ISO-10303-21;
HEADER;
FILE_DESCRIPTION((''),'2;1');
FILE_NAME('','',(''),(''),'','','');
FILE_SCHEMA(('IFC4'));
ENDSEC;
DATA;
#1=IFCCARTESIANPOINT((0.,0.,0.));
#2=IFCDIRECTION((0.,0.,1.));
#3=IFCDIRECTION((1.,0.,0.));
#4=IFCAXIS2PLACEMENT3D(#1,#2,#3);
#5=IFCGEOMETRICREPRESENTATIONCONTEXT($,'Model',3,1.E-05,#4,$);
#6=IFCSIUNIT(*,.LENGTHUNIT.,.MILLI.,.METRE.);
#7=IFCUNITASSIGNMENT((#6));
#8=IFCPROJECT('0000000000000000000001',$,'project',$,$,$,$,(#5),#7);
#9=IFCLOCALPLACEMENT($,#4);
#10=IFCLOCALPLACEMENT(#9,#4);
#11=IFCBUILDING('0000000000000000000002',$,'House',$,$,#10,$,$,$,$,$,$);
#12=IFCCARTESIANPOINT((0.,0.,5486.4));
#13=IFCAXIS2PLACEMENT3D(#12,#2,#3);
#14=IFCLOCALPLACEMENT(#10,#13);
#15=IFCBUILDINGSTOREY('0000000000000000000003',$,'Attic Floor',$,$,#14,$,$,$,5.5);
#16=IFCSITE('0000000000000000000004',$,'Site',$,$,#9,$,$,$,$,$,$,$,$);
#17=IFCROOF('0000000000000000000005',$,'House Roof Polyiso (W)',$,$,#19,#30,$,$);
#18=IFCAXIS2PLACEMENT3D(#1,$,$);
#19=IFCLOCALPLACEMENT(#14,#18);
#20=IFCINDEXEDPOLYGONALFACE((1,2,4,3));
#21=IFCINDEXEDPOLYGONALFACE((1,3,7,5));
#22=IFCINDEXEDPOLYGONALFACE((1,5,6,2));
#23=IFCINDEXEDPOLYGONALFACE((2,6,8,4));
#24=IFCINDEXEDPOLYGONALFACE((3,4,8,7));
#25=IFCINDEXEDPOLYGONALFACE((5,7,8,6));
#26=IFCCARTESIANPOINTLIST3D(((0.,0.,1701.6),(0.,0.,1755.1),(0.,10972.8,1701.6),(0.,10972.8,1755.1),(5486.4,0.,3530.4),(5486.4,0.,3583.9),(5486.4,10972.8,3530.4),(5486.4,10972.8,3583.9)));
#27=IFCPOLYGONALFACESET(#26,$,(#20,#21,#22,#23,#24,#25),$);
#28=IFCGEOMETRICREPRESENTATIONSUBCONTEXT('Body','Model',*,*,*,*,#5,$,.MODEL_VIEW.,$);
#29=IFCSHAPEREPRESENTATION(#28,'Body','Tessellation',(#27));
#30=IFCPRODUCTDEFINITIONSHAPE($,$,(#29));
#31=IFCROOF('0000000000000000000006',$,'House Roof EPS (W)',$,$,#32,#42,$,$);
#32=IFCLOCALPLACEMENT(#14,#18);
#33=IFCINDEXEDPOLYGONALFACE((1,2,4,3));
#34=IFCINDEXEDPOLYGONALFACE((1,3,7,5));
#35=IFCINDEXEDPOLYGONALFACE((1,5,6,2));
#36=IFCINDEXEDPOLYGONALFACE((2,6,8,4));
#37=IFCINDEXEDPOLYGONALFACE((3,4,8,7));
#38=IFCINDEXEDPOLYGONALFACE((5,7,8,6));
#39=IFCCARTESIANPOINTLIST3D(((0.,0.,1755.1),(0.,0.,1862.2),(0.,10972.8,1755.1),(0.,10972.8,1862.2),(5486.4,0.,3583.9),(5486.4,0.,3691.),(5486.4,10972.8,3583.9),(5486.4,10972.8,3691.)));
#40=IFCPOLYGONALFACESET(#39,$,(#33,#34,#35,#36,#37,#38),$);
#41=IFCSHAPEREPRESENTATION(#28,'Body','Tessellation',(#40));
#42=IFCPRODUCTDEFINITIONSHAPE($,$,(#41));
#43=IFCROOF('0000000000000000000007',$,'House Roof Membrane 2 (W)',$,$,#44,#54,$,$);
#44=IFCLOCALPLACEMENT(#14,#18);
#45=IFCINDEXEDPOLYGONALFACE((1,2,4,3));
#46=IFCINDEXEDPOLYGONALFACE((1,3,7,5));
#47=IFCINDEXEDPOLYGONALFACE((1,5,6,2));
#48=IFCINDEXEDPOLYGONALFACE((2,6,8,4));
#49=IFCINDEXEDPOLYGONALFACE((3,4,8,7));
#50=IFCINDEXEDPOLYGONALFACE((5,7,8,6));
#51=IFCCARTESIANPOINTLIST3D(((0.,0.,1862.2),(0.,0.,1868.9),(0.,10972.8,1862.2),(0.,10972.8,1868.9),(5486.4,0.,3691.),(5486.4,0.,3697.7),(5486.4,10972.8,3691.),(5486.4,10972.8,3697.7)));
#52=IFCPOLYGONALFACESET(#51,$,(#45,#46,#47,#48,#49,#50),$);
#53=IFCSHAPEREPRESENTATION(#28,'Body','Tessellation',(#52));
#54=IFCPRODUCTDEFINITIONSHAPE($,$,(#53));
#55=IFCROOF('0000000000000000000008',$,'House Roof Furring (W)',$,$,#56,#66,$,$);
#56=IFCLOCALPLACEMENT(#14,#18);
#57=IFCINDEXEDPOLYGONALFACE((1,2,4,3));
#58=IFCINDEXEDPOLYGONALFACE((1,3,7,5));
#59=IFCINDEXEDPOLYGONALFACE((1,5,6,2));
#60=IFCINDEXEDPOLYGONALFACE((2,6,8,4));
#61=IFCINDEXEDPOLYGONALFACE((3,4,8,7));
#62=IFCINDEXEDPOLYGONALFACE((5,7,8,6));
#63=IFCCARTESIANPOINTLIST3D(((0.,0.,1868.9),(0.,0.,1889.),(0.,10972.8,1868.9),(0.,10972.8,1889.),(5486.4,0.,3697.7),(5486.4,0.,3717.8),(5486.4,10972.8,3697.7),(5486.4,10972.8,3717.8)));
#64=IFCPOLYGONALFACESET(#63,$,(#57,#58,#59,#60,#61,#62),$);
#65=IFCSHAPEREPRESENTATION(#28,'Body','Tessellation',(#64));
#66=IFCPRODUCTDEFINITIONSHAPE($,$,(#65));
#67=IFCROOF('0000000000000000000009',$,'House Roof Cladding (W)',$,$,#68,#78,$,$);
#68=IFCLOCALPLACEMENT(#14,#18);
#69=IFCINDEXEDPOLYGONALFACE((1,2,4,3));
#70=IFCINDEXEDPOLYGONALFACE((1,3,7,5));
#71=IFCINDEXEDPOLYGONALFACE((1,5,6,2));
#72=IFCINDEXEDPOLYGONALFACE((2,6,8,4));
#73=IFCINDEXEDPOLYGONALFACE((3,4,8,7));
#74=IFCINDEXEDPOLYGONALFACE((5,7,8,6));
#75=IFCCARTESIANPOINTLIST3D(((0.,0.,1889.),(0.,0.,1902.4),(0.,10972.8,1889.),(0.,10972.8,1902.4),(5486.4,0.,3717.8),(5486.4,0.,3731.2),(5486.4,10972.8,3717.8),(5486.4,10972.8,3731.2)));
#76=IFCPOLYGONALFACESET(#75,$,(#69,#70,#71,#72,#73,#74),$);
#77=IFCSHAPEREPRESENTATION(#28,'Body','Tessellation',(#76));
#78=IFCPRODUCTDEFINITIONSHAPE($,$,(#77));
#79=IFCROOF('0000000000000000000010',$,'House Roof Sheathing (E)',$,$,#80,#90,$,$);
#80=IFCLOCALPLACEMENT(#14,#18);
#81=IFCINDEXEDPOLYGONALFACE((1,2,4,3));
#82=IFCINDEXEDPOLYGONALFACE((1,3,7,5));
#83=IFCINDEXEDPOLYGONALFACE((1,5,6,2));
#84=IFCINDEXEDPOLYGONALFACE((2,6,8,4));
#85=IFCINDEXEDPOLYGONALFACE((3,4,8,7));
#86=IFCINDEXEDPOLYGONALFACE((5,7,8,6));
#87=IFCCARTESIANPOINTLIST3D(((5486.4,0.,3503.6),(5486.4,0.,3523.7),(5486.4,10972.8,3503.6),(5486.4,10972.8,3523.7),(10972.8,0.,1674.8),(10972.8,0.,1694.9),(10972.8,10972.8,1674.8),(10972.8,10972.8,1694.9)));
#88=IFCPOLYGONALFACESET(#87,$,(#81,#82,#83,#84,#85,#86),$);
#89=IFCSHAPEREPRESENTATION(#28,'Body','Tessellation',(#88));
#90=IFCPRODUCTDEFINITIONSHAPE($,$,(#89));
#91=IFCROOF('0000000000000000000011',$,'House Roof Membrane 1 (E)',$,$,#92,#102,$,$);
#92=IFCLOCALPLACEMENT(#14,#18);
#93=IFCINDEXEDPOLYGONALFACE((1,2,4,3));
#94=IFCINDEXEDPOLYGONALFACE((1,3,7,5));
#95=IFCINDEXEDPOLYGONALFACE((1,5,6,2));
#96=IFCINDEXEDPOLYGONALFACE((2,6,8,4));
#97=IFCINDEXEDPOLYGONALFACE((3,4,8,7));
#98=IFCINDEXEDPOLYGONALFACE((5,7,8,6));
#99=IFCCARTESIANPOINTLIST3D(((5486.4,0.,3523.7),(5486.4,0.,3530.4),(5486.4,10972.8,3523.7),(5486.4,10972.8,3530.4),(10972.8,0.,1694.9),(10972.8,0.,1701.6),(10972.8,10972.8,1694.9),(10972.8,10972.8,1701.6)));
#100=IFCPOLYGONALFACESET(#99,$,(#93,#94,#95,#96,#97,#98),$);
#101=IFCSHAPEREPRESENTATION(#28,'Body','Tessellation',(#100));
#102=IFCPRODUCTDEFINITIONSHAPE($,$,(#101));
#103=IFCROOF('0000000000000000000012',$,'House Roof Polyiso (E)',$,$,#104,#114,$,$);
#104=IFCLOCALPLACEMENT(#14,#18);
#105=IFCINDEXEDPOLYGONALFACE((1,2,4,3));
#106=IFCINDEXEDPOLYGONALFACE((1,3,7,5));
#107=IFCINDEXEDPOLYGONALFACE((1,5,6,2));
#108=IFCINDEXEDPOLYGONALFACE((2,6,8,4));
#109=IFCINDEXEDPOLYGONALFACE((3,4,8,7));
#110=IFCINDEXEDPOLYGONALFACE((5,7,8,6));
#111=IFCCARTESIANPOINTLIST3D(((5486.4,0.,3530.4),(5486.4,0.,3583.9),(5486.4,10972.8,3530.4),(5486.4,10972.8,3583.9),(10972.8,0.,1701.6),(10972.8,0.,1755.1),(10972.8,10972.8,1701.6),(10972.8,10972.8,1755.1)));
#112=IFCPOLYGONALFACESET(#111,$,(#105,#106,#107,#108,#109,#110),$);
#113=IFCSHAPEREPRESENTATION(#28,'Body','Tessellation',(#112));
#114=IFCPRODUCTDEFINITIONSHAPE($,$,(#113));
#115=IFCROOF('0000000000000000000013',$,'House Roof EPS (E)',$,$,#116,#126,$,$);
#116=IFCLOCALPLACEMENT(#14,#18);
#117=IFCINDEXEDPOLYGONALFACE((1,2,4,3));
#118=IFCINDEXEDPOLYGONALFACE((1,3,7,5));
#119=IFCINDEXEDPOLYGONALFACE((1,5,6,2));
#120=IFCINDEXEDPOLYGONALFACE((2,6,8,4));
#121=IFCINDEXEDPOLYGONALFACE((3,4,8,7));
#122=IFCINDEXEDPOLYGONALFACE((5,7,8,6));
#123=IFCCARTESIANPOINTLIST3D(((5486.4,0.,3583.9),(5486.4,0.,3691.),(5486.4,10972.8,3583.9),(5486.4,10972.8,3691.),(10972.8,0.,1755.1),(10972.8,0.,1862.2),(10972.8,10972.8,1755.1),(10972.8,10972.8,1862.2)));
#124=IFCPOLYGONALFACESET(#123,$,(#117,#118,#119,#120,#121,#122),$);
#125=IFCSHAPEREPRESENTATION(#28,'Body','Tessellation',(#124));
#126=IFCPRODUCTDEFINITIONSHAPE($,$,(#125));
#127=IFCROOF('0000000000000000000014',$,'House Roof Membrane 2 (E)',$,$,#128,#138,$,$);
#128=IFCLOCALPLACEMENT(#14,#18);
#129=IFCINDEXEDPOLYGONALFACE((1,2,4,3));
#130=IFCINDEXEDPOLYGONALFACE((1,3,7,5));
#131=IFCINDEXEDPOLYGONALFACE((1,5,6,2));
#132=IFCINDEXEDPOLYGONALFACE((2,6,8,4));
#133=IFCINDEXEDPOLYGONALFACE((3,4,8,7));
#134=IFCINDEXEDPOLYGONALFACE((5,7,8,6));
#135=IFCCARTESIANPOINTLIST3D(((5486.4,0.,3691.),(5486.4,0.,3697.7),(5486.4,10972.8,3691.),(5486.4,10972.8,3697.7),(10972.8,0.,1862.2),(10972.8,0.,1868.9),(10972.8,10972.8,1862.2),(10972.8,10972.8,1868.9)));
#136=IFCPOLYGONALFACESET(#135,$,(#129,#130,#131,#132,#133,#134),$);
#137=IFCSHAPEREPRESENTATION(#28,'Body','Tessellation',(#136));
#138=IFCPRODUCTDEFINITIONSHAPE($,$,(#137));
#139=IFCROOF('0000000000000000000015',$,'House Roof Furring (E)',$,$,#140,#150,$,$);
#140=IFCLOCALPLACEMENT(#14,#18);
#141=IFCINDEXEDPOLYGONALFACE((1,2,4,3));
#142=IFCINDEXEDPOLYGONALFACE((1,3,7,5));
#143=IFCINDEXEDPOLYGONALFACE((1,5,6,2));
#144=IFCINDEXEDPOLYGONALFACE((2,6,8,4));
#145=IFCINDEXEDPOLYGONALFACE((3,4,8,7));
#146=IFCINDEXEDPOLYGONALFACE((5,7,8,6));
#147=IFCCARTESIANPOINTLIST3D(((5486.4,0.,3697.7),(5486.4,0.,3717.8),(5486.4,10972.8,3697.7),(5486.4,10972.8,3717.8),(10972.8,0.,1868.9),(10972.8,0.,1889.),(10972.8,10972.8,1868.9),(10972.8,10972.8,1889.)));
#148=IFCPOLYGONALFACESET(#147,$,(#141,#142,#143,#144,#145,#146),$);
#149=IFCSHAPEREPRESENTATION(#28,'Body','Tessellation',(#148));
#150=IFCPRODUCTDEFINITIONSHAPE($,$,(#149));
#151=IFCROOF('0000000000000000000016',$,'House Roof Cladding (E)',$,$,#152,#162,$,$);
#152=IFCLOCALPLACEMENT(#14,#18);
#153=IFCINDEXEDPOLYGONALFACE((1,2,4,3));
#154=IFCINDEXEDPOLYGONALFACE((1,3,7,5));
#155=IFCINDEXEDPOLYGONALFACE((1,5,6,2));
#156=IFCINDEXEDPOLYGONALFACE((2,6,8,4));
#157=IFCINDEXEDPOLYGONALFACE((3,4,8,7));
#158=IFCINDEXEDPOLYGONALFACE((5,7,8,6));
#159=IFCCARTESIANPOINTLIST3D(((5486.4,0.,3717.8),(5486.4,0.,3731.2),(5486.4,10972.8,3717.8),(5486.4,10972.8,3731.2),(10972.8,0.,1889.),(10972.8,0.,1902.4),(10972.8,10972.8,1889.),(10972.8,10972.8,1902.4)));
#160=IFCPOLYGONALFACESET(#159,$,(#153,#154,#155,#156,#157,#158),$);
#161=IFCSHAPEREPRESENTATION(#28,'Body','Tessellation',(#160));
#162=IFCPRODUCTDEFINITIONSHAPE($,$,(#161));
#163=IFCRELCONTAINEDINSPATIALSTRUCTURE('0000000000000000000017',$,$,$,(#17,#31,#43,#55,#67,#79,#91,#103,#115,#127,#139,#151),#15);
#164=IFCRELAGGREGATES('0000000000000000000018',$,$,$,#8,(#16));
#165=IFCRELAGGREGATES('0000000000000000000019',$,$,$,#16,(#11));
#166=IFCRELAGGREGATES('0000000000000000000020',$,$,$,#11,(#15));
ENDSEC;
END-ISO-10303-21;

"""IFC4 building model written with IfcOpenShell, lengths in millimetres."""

from ifc_helpers import new_model, si_unit, frame, origin_with_axes, place, context, subcontext, project, spatial, indexed_curve, outline, extrude, element, save


model = new_model("IFC4")

# Units and contexts
model_context = context("Model", 3, precision=1e-05, world=origin_with_axes())
body_context = subcontext(model_context, "Body", "Model", "MODEL_VIEW")
ifc_project = project(units=[si_unit("LENGTHUNIT", "METRE", prefix="MILLI")], contexts=[model_context])

# Site, building, storey
site_placement = place(None, origin_with_axes())
site = spatial("IfcSite", under=ifc_project, at=site_placement, Name="Site")
building_placement = place(site_placement, origin_with_axes())
building = spatial("IfcBuilding", under=site, at=building_placement, Name="House")
storey_placement = place(building_placement, frame((0.0, 0.0, 5486.4), z_axis=(0.0, 0.0, 1.0), x_axis=(1.0, 0.0, 0.0)))
storey = spatial("IfcBuildingStorey", under=building, at=storey_placement, Name="Attic Floor", Elevation=5.5)

# Roofs
roof_1_placement = place(storey_placement, frame((0.0, 0.0, 0.0), z_axis=(0.0, 1.0, 0.0), x_axis=(1.0, 0.0, 0.0)))
element("IfcRoof", 1, at=roof_1_placement, inside=storey, Name="House Roof Polyiso (W)", context=body_context, shape_type="SweptSolid", body=[
    extrude(outline(indexed_curve([(0.0, -1755.1), (5486.4, -3583.9), (5486.4, -3530.4), (0.0, -1701.6), (0.0, -1755.1)])), origin_with_axes(), (0.0, 0.0, 1.0), 10972.8),
])
roof_2_placement = place(storey_placement, frame((0.0, 0.0, 0.0), z_axis=(0.0, 1.0, 0.0), x_axis=(1.0, 0.0, 0.0)))
element("IfcRoof", 2, at=roof_2_placement, inside=storey, Name="House Roof EPS (W)", context=body_context, shape_type="SweptSolid", body=[
    extrude(outline(indexed_curve([(0.0, -1862.2), (5486.4, -3691.0), (5486.4, -3583.9), (0.0, -1755.1), (0.0, -1862.2)])), origin_with_axes(), (0.0, 0.0, 1.0), 10972.8),
])
roof_3_placement = place(storey_placement, frame((0.0, 0.0, 0.0), z_axis=(0.0, 1.0, 0.0), x_axis=(1.0, 0.0, 0.0)))
element("IfcRoof", 3, at=roof_3_placement, inside=storey, Name="House Roof Membrane 2 (W)", context=body_context, shape_type="SweptSolid", body=[
    extrude(outline(indexed_curve([(0.0, -1868.9), (5486.4, -3697.7), (5486.4, -3691.0), (0.0, -1862.2), (0.0, -1868.9)])), origin_with_axes(), (0.0, 0.0, 1.0), 10972.8),
])
roof_4_placement = place(storey_placement, frame((0.0, 0.0, 0.0), z_axis=(0.0, 1.0, 0.0), x_axis=(1.0, 0.0, 0.0)))
element("IfcRoof", 4, at=roof_4_placement, inside=storey, Name="House Roof Furring (W)", context=body_context, shape_type="SweptSolid", body=[
    extrude(outline(indexed_curve([(0.0, -1889.0), (5486.4, -3717.8), (5486.4, -3697.7), (0.0, -1868.9), (0.0, -1889.0)])), origin_with_axes(), (0.0, 0.0, 1.0), 10972.8),
])
roof_5_placement = place(storey_placement, frame((0.0, 0.0, 0.0), z_axis=(0.0, 1.0, 0.0), x_axis=(1.0, 0.0, 0.0)))
element("IfcRoof", 5, at=roof_5_placement, inside=storey, Name="House Roof Cladding (W)", context=body_context, shape_type="SweptSolid", body=[
    extrude(outline(indexed_curve([(0.0, -1902.4), (5486.4, -3731.2), (5486.4, -3717.8), (0.0, -1889.0), (0.0, -1902.4)])), origin_with_axes(), (0.0, 0.0, 1.0), 10972.8),
])
roof_6_placement = place(storey_placement, frame((0.0, 0.0, 0.0), z_axis=(0.0, 1.0, 0.0), x_axis=(1.0, 0.0, 0.0)))
element("IfcRoof", 6, at=roof_6_placement, inside=storey, Name="House Roof Sheathing (E)", context=body_context, shape_type="SweptSolid", body=[
    extrude(outline(indexed_curve([(5486.4, -3523.7), (10972.8, -1694.9), (10972.8, -1674.8), (5486.4, -3503.6), (5486.4, -3523.7)])), origin_with_axes(), (0.0, 0.0, 1.0), 10972.8),
])
roof_7_placement = place(storey_placement, frame((0.0, 0.0, 0.0), z_axis=(0.0, 1.0, 0.0), x_axis=(1.0, 0.0, 0.0)))
element("IfcRoof", 7, at=roof_7_placement, inside=storey, Name="House Roof Membrane 1 (E)", context=body_context, shape_type="SweptSolid", body=[
    extrude(outline(indexed_curve([(5486.4, -3530.4), (10972.8, -1701.6), (10972.8, -1694.9), (5486.4, -3523.7), (5486.4, -3530.4)])), origin_with_axes(), (0.0, 0.0, 1.0), 10972.8),
])
roof_8_placement = place(storey_placement, frame((0.0, 0.0, 0.0), z_axis=(0.0, 1.0, 0.0), x_axis=(1.0, 0.0, 0.0)))
element("IfcRoof", 8, at=roof_8_placement, inside=storey, Name="House Roof Polyiso (E)", context=body_context, shape_type="SweptSolid", body=[
    extrude(outline(indexed_curve([(5486.4, -3583.9), (10972.8, -1755.1), (10972.8, -1701.6), (5486.4, -3530.4), (5486.4, -3583.9)])), origin_with_axes(), (0.0, 0.0, 1.0), 10972.8),
])
roof_9_placement = place(storey_placement, frame((0.0, 0.0, 0.0), z_axis=(0.0, 1.0, 0.0), x_axis=(1.0, 0.0, 0.0)))
element("IfcRoof", 9, at=roof_9_placement, inside=storey, Name="House Roof EPS (E)", context=body_context, shape_type="SweptSolid", body=[
    extrude(outline(indexed_curve([(5486.4, -3691.0), (10972.8, -1862.2), (10972.8, -1755.1), (5486.4, -3583.9), (5486.4, -3691.0)])), origin_with_axes(), (0.0, 0.0, 1.0), 10972.8),
])
roof_10_placement = place(storey_placement, frame((0.0, 0.0, 0.0), z_axis=(0.0, 1.0, 0.0), x_axis=(1.0, 0.0, 0.0)))
element("IfcRoof", 10, at=roof_10_placement, inside=storey, Name="House Roof Membrane 2 (E)", context=body_context, shape_type="SweptSolid", body=[
    extrude(outline(indexed_curve([(5486.4, -3697.7), (10972.8, -1868.9), (10972.8, -1862.2), (5486.4, -3691.0), (5486.4, -3697.7)])), origin_with_axes(), (0.0, 0.0, 1.0), 10972.8),
])
roof_11_placement = place(storey_placement, frame((0.0, 0.0, 0.0), z_axis=(0.0, 1.0, 0.0), x_axis=(1.0, 0.0, 0.0)))
element("IfcRoof", 11, at=roof_11_placement, inside=storey, Name="House Roof Furring (E)", context=body_context, shape_type="SweptSolid", body=[
    extrude(outline(indexed_curve([(5486.4, -3717.8), (10972.8, -1889.0), (10972.8, -1868.9), (5486.4, -3697.7), (5486.4, -3717.8)])), origin_with_axes(), (0.0, 0.0, 1.0), 10972.8),
])
roof_12_placement = place(storey_placement, frame((0.0, 0.0, 0.0), z_axis=(0.0, 1.0, 0.0), x_axis=(1.0, 0.0, 0.0)))
element("IfcRoof", 12, at=roof_12_placement, inside=storey, Name="House Roof Cladding (E)", context=body_context, shape_type="SweptSolid", body=[
    extrude(outline(indexed_curve([(5486.4, -3731.2), (10972.8, -1902.4), (10972.8, -1889.0), (5486.4, -3717.8), (5486.4, -3731.2)])), origin_with_axes(), (0.0, 0.0, 1.0), 10972.8),
])

save(model, "model.ifc")
